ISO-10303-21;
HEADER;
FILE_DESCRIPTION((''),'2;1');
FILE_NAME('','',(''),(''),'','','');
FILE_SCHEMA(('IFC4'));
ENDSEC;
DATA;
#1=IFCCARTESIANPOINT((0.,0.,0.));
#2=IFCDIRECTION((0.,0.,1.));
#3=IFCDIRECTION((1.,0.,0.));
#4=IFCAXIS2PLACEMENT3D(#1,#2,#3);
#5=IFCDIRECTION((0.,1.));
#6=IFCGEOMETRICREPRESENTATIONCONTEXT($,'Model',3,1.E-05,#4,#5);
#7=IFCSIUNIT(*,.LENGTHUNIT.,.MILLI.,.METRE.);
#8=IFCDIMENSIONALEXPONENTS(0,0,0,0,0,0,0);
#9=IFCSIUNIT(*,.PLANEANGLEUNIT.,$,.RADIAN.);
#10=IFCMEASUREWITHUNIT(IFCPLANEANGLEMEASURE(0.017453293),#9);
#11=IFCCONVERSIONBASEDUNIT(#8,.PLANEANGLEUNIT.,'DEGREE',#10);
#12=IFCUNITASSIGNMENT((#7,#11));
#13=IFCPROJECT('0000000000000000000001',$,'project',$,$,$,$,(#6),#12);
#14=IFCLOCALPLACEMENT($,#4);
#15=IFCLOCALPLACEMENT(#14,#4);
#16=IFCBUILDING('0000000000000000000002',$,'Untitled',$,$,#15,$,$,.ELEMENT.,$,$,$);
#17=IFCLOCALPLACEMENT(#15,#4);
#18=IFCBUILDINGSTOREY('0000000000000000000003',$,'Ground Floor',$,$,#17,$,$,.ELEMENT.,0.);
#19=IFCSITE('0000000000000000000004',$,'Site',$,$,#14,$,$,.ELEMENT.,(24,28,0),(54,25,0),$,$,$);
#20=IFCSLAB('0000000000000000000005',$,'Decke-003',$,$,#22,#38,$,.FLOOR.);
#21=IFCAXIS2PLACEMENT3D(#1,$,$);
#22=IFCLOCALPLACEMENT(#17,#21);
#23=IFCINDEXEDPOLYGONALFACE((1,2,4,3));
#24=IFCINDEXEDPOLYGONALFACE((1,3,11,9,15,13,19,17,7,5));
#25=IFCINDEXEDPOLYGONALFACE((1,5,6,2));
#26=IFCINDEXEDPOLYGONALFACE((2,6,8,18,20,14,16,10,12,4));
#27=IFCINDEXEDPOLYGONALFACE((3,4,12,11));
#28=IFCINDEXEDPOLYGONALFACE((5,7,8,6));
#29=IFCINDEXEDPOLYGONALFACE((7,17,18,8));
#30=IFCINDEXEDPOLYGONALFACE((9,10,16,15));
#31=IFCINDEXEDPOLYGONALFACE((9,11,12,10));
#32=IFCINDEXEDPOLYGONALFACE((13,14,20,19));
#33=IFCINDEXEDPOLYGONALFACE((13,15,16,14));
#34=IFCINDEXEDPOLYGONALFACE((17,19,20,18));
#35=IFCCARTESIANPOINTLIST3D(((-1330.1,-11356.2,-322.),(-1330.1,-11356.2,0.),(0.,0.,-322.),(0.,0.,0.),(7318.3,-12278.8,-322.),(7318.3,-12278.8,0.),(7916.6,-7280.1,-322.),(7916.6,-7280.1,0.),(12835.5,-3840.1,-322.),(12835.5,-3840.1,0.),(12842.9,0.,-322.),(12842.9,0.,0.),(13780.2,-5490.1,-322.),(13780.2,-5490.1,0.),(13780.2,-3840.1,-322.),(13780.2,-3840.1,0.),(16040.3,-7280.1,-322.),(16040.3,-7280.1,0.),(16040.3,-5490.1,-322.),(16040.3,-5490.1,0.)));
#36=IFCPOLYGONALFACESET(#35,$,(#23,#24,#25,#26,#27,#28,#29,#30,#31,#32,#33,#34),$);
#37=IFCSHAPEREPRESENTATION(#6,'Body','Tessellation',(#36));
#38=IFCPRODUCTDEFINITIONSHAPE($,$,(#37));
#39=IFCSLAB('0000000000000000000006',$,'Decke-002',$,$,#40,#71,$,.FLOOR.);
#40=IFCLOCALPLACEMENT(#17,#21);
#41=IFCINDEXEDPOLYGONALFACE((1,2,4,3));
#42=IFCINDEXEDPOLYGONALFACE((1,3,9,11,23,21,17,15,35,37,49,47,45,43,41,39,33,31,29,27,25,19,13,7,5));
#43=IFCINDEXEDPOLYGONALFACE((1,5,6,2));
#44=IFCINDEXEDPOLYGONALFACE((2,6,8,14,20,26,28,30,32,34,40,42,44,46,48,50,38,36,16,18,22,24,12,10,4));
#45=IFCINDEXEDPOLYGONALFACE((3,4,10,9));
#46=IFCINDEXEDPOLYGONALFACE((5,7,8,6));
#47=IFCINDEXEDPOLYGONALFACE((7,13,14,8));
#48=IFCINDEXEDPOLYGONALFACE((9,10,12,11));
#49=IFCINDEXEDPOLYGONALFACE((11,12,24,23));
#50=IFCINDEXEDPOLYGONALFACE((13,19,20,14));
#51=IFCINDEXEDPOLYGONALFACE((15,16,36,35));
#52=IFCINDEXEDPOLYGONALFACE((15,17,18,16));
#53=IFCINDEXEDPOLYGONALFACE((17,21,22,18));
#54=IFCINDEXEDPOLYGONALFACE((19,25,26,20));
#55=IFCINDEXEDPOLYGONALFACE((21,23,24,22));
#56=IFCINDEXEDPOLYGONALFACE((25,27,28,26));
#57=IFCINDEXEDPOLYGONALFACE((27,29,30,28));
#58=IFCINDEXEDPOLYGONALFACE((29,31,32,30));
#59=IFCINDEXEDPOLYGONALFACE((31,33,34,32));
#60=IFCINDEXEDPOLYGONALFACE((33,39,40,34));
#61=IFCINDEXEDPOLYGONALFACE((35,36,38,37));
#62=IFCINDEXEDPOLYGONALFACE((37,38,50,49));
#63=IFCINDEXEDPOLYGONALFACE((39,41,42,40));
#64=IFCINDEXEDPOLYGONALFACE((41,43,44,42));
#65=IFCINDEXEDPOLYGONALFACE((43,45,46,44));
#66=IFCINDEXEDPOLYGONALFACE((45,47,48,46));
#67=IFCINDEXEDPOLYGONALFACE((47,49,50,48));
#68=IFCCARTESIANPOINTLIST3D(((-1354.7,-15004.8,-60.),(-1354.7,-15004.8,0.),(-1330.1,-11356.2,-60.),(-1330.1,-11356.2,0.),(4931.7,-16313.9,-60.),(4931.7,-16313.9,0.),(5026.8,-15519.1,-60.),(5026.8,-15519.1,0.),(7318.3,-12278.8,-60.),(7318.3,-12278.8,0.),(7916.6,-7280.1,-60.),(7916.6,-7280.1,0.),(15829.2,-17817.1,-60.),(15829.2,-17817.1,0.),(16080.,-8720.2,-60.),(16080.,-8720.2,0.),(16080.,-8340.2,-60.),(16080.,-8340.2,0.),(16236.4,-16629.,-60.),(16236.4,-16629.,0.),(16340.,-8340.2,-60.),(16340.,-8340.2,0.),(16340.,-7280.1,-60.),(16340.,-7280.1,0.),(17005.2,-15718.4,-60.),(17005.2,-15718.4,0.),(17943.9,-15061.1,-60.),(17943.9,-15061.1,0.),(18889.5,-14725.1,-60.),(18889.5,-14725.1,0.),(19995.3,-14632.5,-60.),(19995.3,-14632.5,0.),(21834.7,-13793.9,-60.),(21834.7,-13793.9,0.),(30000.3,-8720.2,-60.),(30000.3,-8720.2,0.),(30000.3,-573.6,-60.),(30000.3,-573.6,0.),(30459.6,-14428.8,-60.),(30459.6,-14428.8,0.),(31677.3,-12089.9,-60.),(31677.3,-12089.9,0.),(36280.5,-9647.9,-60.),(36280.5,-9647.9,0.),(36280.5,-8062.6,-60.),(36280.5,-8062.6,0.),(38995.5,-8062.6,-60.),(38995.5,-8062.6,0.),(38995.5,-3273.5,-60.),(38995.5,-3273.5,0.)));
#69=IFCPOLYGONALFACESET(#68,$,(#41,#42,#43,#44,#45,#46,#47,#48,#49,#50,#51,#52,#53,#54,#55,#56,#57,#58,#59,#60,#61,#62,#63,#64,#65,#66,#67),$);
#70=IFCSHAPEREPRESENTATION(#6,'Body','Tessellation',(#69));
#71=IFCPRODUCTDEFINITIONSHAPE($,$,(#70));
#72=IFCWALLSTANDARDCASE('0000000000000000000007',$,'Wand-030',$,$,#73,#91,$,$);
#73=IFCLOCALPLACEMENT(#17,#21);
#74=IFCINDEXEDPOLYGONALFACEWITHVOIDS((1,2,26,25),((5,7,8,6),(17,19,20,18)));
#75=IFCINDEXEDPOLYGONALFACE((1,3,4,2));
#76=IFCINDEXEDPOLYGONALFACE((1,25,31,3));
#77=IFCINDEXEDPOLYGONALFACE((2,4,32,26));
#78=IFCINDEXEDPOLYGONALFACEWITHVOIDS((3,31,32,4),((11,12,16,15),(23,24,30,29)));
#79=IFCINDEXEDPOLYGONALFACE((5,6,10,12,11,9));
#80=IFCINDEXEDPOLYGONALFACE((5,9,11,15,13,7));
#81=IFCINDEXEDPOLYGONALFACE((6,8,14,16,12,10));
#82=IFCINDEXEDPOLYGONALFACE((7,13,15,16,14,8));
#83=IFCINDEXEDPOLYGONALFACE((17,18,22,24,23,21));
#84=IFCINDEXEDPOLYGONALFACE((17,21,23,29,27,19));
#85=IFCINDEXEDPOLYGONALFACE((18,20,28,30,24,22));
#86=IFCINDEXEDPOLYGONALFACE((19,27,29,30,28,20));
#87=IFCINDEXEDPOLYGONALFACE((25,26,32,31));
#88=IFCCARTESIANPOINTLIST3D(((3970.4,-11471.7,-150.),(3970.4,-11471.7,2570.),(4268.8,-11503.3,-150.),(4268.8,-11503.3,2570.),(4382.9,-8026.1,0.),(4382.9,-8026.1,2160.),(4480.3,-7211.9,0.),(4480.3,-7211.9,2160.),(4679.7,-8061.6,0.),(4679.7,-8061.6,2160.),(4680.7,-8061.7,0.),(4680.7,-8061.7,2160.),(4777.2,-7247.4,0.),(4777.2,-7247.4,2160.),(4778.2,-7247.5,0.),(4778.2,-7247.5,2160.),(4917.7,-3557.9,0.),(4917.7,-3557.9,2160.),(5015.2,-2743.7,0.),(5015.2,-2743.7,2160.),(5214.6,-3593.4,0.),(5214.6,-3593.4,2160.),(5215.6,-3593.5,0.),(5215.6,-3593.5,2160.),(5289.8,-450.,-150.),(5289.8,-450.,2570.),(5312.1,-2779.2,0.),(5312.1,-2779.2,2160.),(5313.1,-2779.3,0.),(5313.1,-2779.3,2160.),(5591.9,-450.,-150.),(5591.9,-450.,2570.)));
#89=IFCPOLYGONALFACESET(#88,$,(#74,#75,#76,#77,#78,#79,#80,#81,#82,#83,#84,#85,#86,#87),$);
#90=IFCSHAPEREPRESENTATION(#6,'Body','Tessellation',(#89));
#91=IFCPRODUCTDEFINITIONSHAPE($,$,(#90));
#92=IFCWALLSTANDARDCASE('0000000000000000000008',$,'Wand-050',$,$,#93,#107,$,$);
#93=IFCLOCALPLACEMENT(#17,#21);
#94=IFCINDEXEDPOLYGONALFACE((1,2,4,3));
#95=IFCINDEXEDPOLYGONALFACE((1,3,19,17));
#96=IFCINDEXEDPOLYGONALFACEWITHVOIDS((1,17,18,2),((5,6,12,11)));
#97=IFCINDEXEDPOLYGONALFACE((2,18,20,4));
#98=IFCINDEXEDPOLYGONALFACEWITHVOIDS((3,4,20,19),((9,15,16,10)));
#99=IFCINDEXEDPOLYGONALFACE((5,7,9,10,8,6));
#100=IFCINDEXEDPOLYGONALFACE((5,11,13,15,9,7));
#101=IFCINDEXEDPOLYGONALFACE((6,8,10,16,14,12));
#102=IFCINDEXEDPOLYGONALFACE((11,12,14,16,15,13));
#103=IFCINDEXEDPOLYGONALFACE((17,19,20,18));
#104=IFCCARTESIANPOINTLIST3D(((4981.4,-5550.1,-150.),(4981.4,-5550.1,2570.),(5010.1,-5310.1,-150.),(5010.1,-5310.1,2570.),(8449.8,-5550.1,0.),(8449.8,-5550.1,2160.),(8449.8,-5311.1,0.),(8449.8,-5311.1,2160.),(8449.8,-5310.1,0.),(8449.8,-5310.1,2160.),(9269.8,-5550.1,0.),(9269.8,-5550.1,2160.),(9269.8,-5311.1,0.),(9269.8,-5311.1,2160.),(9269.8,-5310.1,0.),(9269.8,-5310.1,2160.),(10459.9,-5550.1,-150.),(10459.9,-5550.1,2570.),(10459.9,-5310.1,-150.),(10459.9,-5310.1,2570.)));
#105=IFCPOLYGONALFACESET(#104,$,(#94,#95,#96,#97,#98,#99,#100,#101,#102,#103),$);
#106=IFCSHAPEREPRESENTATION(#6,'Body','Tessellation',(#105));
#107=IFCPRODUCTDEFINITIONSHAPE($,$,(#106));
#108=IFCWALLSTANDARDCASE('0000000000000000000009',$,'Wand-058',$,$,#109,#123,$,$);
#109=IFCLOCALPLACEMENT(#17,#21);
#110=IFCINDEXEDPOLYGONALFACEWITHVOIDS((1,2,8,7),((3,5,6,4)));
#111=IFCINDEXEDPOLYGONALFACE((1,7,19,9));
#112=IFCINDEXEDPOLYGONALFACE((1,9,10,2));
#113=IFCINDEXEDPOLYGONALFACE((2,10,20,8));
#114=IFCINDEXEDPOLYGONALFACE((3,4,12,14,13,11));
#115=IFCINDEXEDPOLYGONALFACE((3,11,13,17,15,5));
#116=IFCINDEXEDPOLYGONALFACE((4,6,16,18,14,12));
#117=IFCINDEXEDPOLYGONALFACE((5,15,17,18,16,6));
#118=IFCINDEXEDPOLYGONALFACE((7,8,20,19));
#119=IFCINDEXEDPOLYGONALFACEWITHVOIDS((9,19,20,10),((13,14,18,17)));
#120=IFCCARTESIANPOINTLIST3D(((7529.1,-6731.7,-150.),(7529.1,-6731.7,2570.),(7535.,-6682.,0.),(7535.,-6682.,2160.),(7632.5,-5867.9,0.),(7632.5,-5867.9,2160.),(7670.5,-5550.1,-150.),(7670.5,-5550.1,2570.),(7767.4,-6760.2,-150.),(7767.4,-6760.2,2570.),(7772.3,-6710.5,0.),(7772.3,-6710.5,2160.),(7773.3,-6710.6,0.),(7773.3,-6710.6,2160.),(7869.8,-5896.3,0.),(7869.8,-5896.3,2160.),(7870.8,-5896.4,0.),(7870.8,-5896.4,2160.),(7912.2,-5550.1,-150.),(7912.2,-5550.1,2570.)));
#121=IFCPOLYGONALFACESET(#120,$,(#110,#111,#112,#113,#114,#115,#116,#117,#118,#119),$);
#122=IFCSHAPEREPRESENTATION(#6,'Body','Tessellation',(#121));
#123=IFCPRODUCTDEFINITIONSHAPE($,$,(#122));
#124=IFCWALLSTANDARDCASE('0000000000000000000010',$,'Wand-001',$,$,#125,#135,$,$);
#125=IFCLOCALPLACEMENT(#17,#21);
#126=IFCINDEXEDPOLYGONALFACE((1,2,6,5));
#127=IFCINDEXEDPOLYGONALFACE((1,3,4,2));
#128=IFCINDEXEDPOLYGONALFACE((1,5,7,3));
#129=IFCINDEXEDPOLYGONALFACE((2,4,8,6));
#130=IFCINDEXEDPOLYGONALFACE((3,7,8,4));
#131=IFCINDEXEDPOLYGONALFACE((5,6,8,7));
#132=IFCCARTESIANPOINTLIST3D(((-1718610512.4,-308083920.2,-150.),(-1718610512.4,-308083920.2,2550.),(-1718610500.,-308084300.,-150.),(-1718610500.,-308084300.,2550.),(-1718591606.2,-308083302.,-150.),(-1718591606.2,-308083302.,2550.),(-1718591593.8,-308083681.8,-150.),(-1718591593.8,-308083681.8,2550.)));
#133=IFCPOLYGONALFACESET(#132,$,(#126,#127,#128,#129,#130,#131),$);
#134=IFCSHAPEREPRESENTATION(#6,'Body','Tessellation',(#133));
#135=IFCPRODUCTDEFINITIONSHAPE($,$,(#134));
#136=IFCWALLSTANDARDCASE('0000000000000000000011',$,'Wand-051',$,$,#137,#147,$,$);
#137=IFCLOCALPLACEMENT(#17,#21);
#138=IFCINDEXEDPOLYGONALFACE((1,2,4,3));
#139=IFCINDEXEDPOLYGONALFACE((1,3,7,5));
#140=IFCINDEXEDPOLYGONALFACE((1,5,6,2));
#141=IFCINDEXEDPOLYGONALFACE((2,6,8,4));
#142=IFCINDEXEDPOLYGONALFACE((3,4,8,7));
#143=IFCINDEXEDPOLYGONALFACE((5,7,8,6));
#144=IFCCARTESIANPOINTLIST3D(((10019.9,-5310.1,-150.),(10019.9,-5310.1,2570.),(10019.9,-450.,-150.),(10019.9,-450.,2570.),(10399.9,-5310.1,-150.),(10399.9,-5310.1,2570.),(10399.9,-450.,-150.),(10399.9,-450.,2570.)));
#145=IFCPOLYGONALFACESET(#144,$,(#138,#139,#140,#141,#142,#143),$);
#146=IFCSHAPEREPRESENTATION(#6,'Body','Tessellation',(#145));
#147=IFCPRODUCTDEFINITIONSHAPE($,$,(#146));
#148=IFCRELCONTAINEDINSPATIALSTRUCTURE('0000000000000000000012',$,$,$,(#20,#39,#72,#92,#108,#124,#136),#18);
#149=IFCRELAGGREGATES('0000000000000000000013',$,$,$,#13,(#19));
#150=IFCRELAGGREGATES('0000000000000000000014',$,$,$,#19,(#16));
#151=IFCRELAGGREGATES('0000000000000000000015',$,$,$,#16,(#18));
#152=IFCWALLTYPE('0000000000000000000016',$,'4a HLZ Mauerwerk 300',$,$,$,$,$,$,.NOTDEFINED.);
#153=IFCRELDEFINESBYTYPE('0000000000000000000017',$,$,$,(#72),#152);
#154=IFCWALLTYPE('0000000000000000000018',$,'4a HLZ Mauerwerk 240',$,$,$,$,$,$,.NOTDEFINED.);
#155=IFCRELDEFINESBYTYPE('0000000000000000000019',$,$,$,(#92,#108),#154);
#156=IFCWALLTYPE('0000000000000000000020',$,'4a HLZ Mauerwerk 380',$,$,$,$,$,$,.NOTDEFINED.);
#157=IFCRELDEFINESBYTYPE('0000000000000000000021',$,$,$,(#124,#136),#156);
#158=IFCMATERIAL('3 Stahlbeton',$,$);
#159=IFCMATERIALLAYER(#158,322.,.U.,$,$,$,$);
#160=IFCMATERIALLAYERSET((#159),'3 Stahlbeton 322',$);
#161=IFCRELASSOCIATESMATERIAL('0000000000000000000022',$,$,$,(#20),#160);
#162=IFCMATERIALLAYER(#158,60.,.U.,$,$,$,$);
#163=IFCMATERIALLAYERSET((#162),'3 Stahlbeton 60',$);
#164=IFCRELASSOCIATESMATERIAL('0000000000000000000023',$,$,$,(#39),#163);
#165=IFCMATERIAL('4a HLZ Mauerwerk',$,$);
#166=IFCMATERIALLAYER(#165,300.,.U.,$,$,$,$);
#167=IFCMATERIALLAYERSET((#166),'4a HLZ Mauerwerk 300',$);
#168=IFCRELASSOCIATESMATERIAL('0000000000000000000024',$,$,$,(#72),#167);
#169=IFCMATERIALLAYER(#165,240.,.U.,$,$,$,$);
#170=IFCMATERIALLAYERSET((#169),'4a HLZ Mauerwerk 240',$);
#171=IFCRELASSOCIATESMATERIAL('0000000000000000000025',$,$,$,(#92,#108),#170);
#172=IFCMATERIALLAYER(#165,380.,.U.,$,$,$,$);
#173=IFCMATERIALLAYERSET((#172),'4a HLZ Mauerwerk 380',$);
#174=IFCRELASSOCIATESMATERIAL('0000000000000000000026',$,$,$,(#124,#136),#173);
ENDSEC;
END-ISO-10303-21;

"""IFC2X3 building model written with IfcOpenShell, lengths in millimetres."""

from ifc_helpers import new_model, entity, si_unit, converted_unit, direction, frame, origin_with_axes, origin_2d_with_axis, place, context, project, spatial, polyline, rectangle, outline, extrude, material, layer, layer_set, layer_usage, type_object, element, save


model = new_model("IFC2X3")

# Units and contexts
model_context = context("Model", 3, precision=1e-05, world=origin_with_axes(), true_north=direction((0.0, 1.0)))
ifc_project = project(units=[si_unit("LENGTHUNIT", "METRE", prefix="MILLI"), converted_unit("PLANEANGLEUNIT", "DEGREE", entity("IfcPlaneAngleMeasure", 0.017453293), si_unit("PLANEANGLEUNIT", "RADIAN"), dimensions=[0, 0, 0, 0, 0, 0, 0])], contexts=[model_context])

# Site, building, storey
site_placement = place(None, origin_with_axes())
site = spatial("IfcSite", under=ifc_project, at=site_placement, Name="Site", CompositionType="ELEMENT", RefLatitude=(24, 28, 0), RefLongitude=(54, 25, 0))
building_placement = place(site_placement, origin_with_axes())
building = spatial("IfcBuilding", under=site, at=building_placement, Name="Untitled", CompositionType="ELEMENT")
storey_placement = place(building_placement, origin_with_axes())
storey = spatial("IfcBuildingStorey", under=building, at=storey_placement, Name="Ground Floor", CompositionType="ELEMENT", Elevation=0.0)

# Slabs
ifc_material_1 = material(Name="3 Stahlbeton")
ifc_layer_1 = layer(ifc_material_1, 322.0, ventilated="UNKNOWN")
ifc_layer_set_1 = layer_set([ifc_layer_1], Name="3 Stahlbeton 322")
ifc_layer_usage_1 = layer_usage(ifc_layer_set_1, "AXIS3", "NEGATIVE", 322.0)
slab_1_placement = place(storey_placement, frame((0.0, 0.0, -322.0), z_axis=(0.0, 0.0, 1.0), x_axis=(1.0, 0.0, 0.0)))
element("IfcSlab", 1, at=slab_1_placement, inside=storey, material=ifc_layer_usage_1, Name="Decke-003", PredefinedType="FLOOR", context=model_context, shape_type="SweptSolid", body=[
    extrude(outline(polyline([(0.0, 0.0), (-1330.1, -11356.2), (7318.3, -12278.8), (7916.6, -7280.1), (16040.3, -7280.1), (16040.3, -5490.1), (13780.2, -5490.1), (13780.2, -3840.1), (12835.5, -3840.1), (12842.9, 0.0), (0.0, 0.0)])), origin_with_axes(), (0.0, 0.0, 1.0), 322.0),
])
ifc_layer_2 = layer(ifc_material_1, 60.0, ventilated="UNKNOWN")
ifc_layer_set_2 = layer_set([ifc_layer_2], Name="3 Stahlbeton 60")
ifc_layer_usage_2 = layer_usage(ifc_layer_set_2, "AXIS3", "NEGATIVE", 60.0)
slab_2_placement = place(storey_placement, frame((-1330.1, -11356.2, -60.0), z_axis=(0.0, 0.0, 1.0), x_axis=(1.0, 0.0, 0.0)))
element("IfcSlab", 2, at=slab_2_placement, inside=storey, material=ifc_layer_usage_2, Name="Decke-002", PredefinedType="FLOOR", context=model_context, shape_type="SweptSolid", body=[
    extrude(outline(polyline([(0.0, 0.0), (-24.6, -3648.6), (6261.8, -4957.7), (6357.0, -4162.9), (17159.3, -6460.9), (17566.5, -5272.8), (18335.3, -4362.2), (19274.0, -3704.9), (20219.7, -3368.9), (21325.4, -3276.3), (23164.8, -2437.7), (31789.7, -3072.6), (33007.4, -733.7), (37610.6, 1708.4), (37610.6, 3293.6), (40325.6, 3293.6), (40325.6, 8082.7), (31330.4, 10782.6), (31330.4, 2636.0), (17410.1, 2636.0), (17410.1, 3016.0), (17670.1, 3016.0), (17670.1, 4076.1), (9246.7, 4076.1), (8648.4, -922.6), (0.0, 0.0)])), origin_with_axes(), (0.0, 0.0, 1.0), 60.0),
])

# Wall, openings
ifc_material_2 = material(Name="4a HLZ Mauerwerk")
ifc_layer_3 = layer(ifc_material_2, 300.0, ventilated="UNKNOWN")
ifc_layer_set_3 = layer_set([ifc_layer_3], Name="4a HLZ Mauerwerk 300")
ifc_layer_usage_3 = layer_usage(ifc_layer_set_3, "AXIS2", "POSITIVE", 0.0)
wall_type_1 = type_object("IfcWallType", Name="4a HLZ Mauerwerk 300", PredefinedType="NOTDEFINED")
wall_1_placement = place(storey_placement, frame((5289.8, -450.0, -150.0), z_axis=(0.0, 0.0, 1.0), x_axis=(-0.118857, -0.992911, 0.0)))
wall_1 = element("IfcWallStandardCase", 3, at=wall_1_placement, inside=storey, type_object=wall_type_1, material=ifc_layer_usage_3, Name="Wand-030", context=model_context, shape_type="SweptSolid", body=[
    extrude(outline(polyline([(0.0, 0.0), (11100.4, 0.0), (11096.3, 300.0), (-35.9, 300.0), (0.0, 0.0)])), origin_with_axes(), (0.0, 0.0, 1.0), 2720.0),
])
opening_1_placement = place(wall_1_placement, frame((7220.2, 0.0, 150.0), z_axis=(0.0, 0.0, 1.0), x_axis=(1.0, 0.0, 0.0)))
element("IfcOpeningElement", 4, at=opening_1_placement, cuts=wall_1, context=model_context, shape_type="SweptSolid", body=[
    extrude(rectangle(XDim=820.0, YDim=2160.0, at=origin_2d_with_axis()), frame((0.0, 901.0, 1080.0), z_axis=(0.0, -1.0, 0.0), x_axis=(1.0, 0.0, 0.0)), (0.0, 0.0, 1.0), 602.0),
    extrude(rectangle(XDim=820.0, YDim=2160.0, at=origin_2d_with_axis()), frame((0.0, -301.0, 1080.0), z_axis=(0.0, 1.0, 0.0), x_axis=(1.0, 0.0, 0.0)), (0.0, 0.0, 1.0), 602.0),
])
opening_2_placement = place(wall_1_placement, frame((2720.1, 0.0, 150.0), z_axis=(0.0, 0.0, 1.0), x_axis=(1.0, 0.0, 0.0)))
element("IfcOpeningElement", 5, at=opening_2_placement, cuts=wall_1, context=model_context, shape_type="SweptSolid", body=[
    extrude(rectangle(XDim=820.0, YDim=2160.0, at=origin_2d_with_axis()), frame((0.0, 901.0, 1080.0), z_axis=(0.0, -1.0, 0.0), x_axis=(1.0, 0.0, 0.0)), (0.0, 0.0, 1.0), 602.0),
    extrude(rectangle(XDim=820.0, YDim=2160.0, at=origin_2d_with_axis()), frame((0.0, -301.0, 1080.0), z_axis=(0.0, 1.0, 0.0), x_axis=(1.0, 0.0, 0.0)), (0.0, 0.0, 1.0), 602.0),
])

# Wall, opening
ifc_layer_4 = layer(ifc_material_2, 240.0, ventilated="UNKNOWN")
ifc_layer_set_4 = layer_set([ifc_layer_4], Name="4a HLZ Mauerwerk 240")
ifc_layer_usage_4 = layer_usage(ifc_layer_set_4, "AXIS2", "NEGATIVE", 0.0)
wall_type_2 = type_object("IfcWallType", Name="4a HLZ Mauerwerk 240", PredefinedType="NOTDEFINED")
wall_2_placement = place(storey_placement, frame((10459.9, -5550.1, -150.0), z_axis=(0.0, 0.0, 1.0), x_axis=(-1.0, 0.0, 0.0)))
wall_2 = element("IfcWallStandardCase", 6, at=wall_2_placement, inside=storey, type_object=wall_type_2, material=ifc_layer_usage_4, Name="Wand-050", context=model_context, shape_type="SweptSolid", body=[
    extrude(outline(polyline([(0.0, -240.0), (5449.8, -240.0), (5478.5, 0.0), (0.0, 0.0), (0.0, -240.0)])), origin_with_axes(), (0.0, 0.0, 1.0), 2720.0),
])
opening_3_placement = place(wall_2_placement, frame((1600.0, 0.0, 150.0), z_axis=(0.0, 0.0, 1.0), x_axis=(1.0, 0.0, 0.0)))
element("IfcOpeningElement", 7, at=opening_3_placement, cuts=wall_2, context=model_context, shape_type="SweptSolid", body=[
    extrude(rectangle(XDim=820.0, YDim=2160.0, at=origin_2d_with_axis()), frame((0.0, -721.0, 1080.0), z_axis=(0.0, 1.0, 0.0), x_axis=(1.0, 0.0, 0.0)), (0.0, 0.0, 1.0), 482.0),
    extrude(rectangle(XDim=820.0, YDim=2160.0, at=origin_2d_with_axis()), frame((0.0, 241.0, 1080.0), z_axis=(0.0, -1.0, 0.0), x_axis=(1.0, 0.0, 0.0)), (0.0, 0.0, 1.0), 482.0),
])

# Wall, opening
ifc_layer_usage_5 = layer_usage(ifc_layer_set_4, "AXIS2", "POSITIVE", 0.0)
wall_3_placement = place(storey_placement, frame((7670.5, -5550.1, -150.0), z_axis=(0.0, 0.0, 1.0), x_axis=(-0.118857, -0.992911, 0.0)))
wall_3 = element("IfcWallStandardCase", 8, at=wall_3_placement, inside=storey, type_object=wall_type_2, material=ifc_layer_usage_5, Name="Wand-058", context=model_context, shape_type="SweptSolid", body=[
    extrude(outline(polyline([(0.0, 0.0), (1190.0, 0.0), (1190.0, 240.0), (-28.7, 240.0), (0.0, 0.0)])), origin_with_axes(), (0.0, 0.0, 1.0), 2720.0),
])
opening_4_placement = place(wall_3_placement, frame((730.0, 0.0, 150.0), z_axis=(0.0, 0.0, 1.0), x_axis=(1.0, 0.0, 0.0)))
element("IfcOpeningElement", 9, at=opening_4_placement, cuts=wall_3, context=model_context, shape_type="SweptSolid", body=[
    extrude(rectangle(XDim=820.0, YDim=2160.0, at=origin_2d_with_axis()), frame((0.0, 721.0, 1080.0), z_axis=(0.0, -1.0, 0.0), x_axis=(1.0, 0.0, 0.0)), (0.0, 0.0, 1.0), 482.0),
    extrude(rectangle(XDim=820.0, YDim=2160.0, at=origin_2d_with_axis()), frame((0.0, -241.0, 1080.0), z_axis=(0.0, 1.0, 0.0), x_axis=(1.0, 0.0, 0.0)), (0.0, 0.0, 1.0), 482.0),
])

# Walls
ifc_layer_5 = layer(ifc_material_2, 380.0, ventilated="UNKNOWN")
ifc_layer_set_5 = layer_set([ifc_layer_5], Name="4a HLZ Mauerwerk 380")
ifc_layer_usage_6 = layer_usage(ifc_layer_set_5, "AXIS2", "POSITIVE", 0.0)
wall_type_3 = type_object("IfcWallType", Name="4a HLZ Mauerwerk 380", PredefinedType="NOTDEFINED")
wall_4_placement = place(storey_placement, frame((-1718610500.0, -308084300.0, -150.0), z_axis=(0.0, 0.0, 1.0), x_axis=(0.999466, 0.03268, 0.0)))
element("IfcWallStandardCase", 10, at=wall_4_placement, inside=storey, type_object=wall_type_3, material=ifc_layer_usage_6, Name="Wand-001", context=model_context, shape_type="SweptSolid", body=[
    extrude(outline(polyline([(0.0, 0.0), (18916.3, 0.0), (18916.3, 380.0), (0.0, 380.0), (0.0, 0.0)])), origin_with_axes(), (0.0, 0.0, 1.0), 2700.0),
])
ifc_layer_usage_7 = layer_usage(ifc_layer_set_5, "AXIS2", "POSITIVE", 0.0)
wall_5_placement = place(storey_placement, frame((10019.9, -450.0, -150.0), z_axis=(0.0, 0.0, 1.0), x_axis=(0.0, -1.0, 0.0)))
element("IfcWallStandardCase", 11, at=wall_5_placement, inside=storey, type_object=wall_type_3, material=ifc_layer_usage_7, Name="Wand-051", context=model_context, shape_type="SweptSolid", body=[
    extrude(outline(polyline([(0.0, 0.0), (4860.1, 0.0), (4860.1, 380.0), (0.0, 380.0), (0.0, 0.0)])), origin_with_axes(), (0.0, 0.0, 1.0), 2720.0),
])

save(model, "model.ifc")
